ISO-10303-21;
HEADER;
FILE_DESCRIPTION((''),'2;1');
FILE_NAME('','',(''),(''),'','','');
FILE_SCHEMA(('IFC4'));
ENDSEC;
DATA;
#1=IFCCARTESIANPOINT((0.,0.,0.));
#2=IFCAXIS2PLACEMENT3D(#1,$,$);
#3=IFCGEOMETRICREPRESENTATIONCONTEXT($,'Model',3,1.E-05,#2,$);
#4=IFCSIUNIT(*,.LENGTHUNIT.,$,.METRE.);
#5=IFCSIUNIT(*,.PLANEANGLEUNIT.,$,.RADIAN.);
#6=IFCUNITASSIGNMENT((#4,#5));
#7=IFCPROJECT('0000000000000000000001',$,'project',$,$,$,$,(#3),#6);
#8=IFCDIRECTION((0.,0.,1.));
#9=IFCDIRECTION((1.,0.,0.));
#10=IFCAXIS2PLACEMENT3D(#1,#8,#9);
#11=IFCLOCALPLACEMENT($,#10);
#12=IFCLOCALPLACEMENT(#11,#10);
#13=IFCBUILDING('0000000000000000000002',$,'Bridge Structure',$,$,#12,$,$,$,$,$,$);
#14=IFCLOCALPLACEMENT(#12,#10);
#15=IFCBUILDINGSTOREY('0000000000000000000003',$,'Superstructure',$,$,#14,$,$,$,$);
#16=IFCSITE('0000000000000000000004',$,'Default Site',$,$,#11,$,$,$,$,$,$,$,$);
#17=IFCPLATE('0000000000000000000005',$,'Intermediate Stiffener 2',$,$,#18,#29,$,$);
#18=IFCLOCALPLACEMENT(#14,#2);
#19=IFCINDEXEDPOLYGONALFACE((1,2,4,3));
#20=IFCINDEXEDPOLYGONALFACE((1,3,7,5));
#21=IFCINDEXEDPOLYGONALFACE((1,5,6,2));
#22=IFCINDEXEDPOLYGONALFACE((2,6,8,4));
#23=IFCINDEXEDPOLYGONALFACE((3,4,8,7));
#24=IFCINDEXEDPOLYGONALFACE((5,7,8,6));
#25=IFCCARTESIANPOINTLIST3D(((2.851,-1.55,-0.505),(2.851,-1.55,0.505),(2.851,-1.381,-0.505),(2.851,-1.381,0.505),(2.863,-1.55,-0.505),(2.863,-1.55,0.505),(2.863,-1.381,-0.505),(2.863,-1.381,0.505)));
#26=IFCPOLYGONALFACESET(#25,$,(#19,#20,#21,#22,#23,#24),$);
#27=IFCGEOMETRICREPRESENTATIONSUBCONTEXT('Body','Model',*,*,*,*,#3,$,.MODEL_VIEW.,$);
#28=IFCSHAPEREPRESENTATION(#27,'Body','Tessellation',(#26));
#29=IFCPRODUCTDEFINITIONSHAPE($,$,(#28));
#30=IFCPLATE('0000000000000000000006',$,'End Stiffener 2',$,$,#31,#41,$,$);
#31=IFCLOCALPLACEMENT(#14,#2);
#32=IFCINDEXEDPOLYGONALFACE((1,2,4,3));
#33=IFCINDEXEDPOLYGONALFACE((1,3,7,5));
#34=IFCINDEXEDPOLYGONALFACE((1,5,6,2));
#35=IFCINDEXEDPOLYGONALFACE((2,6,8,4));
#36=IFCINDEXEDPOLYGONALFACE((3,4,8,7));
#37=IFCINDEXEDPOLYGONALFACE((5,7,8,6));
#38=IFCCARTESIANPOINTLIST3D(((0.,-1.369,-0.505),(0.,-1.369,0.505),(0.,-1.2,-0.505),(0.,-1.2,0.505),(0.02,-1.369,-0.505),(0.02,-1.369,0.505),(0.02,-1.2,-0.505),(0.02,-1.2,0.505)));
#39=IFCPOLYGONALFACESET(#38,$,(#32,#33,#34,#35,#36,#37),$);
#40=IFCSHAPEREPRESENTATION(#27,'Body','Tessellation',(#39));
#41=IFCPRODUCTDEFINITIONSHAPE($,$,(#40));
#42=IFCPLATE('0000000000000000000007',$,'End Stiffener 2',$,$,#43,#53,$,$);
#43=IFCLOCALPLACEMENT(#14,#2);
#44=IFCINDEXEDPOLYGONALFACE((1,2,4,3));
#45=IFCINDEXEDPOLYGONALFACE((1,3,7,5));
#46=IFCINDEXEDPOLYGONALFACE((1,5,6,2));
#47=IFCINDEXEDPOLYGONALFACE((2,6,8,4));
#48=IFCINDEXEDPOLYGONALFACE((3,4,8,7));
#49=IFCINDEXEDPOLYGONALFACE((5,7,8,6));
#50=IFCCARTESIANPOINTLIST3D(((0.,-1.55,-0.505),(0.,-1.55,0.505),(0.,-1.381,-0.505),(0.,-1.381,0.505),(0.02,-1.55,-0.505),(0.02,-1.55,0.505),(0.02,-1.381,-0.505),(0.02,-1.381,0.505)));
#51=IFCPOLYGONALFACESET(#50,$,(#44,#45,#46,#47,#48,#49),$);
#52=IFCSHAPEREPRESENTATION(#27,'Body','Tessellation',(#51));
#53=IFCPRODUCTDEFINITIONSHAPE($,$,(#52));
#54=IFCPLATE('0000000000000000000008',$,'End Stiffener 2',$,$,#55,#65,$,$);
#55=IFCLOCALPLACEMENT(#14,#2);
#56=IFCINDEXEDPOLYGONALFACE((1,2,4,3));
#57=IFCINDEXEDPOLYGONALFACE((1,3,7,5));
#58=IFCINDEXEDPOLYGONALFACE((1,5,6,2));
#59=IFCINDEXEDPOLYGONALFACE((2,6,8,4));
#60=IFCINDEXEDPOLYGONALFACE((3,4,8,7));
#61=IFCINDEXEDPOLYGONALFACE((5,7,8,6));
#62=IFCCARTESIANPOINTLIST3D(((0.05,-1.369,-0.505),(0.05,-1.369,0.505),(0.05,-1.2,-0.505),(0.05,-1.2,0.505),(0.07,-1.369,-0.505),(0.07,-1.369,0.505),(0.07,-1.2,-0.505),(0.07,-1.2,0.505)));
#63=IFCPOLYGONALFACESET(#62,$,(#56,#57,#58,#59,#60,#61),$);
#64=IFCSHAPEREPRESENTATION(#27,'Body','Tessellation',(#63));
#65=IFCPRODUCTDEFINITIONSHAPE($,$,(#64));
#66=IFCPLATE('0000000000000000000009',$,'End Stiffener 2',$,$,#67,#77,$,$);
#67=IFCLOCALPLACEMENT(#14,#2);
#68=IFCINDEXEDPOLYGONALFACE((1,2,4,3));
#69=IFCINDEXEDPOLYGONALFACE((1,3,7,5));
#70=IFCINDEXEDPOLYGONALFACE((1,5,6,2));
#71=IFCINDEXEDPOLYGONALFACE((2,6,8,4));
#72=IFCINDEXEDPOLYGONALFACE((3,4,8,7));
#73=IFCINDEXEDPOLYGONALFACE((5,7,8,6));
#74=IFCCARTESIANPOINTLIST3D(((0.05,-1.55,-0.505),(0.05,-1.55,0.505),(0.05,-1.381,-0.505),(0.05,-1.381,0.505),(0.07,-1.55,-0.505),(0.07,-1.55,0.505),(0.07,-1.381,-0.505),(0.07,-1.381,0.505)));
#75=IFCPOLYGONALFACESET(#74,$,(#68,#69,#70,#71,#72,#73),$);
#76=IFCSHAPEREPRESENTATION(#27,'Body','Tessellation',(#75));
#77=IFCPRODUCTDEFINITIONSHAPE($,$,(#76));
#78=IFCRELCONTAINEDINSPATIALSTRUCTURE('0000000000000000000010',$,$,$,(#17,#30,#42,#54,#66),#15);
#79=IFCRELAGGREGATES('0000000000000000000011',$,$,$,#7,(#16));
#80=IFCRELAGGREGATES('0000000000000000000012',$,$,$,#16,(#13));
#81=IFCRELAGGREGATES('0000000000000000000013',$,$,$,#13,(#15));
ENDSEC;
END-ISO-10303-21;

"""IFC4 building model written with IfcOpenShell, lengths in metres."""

from ifc_helpers import new_model, si_unit, frame, origin, origin_with_axes, origin_2d_with_axis, place, context, subcontext, project, spatial, rectangle, extrude, element, save


model = new_model("IFC4")

# Units and contexts
model_context = context("Model", 3, precision=1e-05, world=origin())
body_context = subcontext(model_context, "Body", "Model", "MODEL_VIEW")
ifc_project = project(units=[si_unit("LENGTHUNIT", "METRE"), si_unit("PLANEANGLEUNIT", "RADIAN")], contexts=[model_context])

# Site, building, storey
site_placement = place(None, origin_with_axes())
site = spatial("IfcSite", under=ifc_project, at=site_placement, Name="Default Site")
building_placement = place(site_placement, origin_with_axes())
building = spatial("IfcBuilding", under=site, at=building_placement, Name="Bridge Structure")
storey_placement = place(building_placement, origin_with_axes())
storey = spatial("IfcBuildingStorey", under=building, at=storey_placement, Name="Superstructure")

# Plates
plate_1_placement = place(storey_placement, frame((2.857, -1.4655, -0.505), z_axis=(0.0, 0.0, 1.0), x_axis=(1.0, 0.0, 0.0)))
element("IfcPlate", 1, at=plate_1_placement, inside=storey, Name="Intermediate Stiffener 2", context=body_context, shape_type="SweptSolid", body=[
    extrude(rectangle(XDim=0.012, YDim=0.169, at=origin_2d_with_axis()), origin_with_axes(), (0.0, 0.0, 1.0), 1.01),
])
for number, where, z_axis, x_axis, name in (
    (2, (0.01, -1.2845, -0.505), (0.0, 0.0, 1.0), (1.0, 0.0, 0.0), "End Stiffener 2"),
    (3, (0.01, -1.4655, -0.505), (0.0, 0.0, 1.0), (1.0, 0.0, 0.0), "End Stiffener 2"),
    (4, (0.06, -1.2845, -0.505), (0.0, 0.0, 1.0), (1.0, 0.0, 0.0), "End Stiffener 2"),
    (5, (0.06, -1.4655, -0.505), (0.0, 0.0, 1.0), (1.0, 0.0, 0.0), "End Stiffener 2"),
):
    element("IfcPlate", number, at=place(storey_placement, frame(where, z_axis=z_axis, x_axis=x_axis)), inside=storey, Name=name, context=body_context, shape_type="SweptSolid", body=[
        extrude(rectangle(XDim=0.02, YDim=0.169, at=origin_2d_with_axis()), origin_with_axes(), (0.0, 0.0, 1.0), 1.01),
    ])

save(model, "model.ifc")
